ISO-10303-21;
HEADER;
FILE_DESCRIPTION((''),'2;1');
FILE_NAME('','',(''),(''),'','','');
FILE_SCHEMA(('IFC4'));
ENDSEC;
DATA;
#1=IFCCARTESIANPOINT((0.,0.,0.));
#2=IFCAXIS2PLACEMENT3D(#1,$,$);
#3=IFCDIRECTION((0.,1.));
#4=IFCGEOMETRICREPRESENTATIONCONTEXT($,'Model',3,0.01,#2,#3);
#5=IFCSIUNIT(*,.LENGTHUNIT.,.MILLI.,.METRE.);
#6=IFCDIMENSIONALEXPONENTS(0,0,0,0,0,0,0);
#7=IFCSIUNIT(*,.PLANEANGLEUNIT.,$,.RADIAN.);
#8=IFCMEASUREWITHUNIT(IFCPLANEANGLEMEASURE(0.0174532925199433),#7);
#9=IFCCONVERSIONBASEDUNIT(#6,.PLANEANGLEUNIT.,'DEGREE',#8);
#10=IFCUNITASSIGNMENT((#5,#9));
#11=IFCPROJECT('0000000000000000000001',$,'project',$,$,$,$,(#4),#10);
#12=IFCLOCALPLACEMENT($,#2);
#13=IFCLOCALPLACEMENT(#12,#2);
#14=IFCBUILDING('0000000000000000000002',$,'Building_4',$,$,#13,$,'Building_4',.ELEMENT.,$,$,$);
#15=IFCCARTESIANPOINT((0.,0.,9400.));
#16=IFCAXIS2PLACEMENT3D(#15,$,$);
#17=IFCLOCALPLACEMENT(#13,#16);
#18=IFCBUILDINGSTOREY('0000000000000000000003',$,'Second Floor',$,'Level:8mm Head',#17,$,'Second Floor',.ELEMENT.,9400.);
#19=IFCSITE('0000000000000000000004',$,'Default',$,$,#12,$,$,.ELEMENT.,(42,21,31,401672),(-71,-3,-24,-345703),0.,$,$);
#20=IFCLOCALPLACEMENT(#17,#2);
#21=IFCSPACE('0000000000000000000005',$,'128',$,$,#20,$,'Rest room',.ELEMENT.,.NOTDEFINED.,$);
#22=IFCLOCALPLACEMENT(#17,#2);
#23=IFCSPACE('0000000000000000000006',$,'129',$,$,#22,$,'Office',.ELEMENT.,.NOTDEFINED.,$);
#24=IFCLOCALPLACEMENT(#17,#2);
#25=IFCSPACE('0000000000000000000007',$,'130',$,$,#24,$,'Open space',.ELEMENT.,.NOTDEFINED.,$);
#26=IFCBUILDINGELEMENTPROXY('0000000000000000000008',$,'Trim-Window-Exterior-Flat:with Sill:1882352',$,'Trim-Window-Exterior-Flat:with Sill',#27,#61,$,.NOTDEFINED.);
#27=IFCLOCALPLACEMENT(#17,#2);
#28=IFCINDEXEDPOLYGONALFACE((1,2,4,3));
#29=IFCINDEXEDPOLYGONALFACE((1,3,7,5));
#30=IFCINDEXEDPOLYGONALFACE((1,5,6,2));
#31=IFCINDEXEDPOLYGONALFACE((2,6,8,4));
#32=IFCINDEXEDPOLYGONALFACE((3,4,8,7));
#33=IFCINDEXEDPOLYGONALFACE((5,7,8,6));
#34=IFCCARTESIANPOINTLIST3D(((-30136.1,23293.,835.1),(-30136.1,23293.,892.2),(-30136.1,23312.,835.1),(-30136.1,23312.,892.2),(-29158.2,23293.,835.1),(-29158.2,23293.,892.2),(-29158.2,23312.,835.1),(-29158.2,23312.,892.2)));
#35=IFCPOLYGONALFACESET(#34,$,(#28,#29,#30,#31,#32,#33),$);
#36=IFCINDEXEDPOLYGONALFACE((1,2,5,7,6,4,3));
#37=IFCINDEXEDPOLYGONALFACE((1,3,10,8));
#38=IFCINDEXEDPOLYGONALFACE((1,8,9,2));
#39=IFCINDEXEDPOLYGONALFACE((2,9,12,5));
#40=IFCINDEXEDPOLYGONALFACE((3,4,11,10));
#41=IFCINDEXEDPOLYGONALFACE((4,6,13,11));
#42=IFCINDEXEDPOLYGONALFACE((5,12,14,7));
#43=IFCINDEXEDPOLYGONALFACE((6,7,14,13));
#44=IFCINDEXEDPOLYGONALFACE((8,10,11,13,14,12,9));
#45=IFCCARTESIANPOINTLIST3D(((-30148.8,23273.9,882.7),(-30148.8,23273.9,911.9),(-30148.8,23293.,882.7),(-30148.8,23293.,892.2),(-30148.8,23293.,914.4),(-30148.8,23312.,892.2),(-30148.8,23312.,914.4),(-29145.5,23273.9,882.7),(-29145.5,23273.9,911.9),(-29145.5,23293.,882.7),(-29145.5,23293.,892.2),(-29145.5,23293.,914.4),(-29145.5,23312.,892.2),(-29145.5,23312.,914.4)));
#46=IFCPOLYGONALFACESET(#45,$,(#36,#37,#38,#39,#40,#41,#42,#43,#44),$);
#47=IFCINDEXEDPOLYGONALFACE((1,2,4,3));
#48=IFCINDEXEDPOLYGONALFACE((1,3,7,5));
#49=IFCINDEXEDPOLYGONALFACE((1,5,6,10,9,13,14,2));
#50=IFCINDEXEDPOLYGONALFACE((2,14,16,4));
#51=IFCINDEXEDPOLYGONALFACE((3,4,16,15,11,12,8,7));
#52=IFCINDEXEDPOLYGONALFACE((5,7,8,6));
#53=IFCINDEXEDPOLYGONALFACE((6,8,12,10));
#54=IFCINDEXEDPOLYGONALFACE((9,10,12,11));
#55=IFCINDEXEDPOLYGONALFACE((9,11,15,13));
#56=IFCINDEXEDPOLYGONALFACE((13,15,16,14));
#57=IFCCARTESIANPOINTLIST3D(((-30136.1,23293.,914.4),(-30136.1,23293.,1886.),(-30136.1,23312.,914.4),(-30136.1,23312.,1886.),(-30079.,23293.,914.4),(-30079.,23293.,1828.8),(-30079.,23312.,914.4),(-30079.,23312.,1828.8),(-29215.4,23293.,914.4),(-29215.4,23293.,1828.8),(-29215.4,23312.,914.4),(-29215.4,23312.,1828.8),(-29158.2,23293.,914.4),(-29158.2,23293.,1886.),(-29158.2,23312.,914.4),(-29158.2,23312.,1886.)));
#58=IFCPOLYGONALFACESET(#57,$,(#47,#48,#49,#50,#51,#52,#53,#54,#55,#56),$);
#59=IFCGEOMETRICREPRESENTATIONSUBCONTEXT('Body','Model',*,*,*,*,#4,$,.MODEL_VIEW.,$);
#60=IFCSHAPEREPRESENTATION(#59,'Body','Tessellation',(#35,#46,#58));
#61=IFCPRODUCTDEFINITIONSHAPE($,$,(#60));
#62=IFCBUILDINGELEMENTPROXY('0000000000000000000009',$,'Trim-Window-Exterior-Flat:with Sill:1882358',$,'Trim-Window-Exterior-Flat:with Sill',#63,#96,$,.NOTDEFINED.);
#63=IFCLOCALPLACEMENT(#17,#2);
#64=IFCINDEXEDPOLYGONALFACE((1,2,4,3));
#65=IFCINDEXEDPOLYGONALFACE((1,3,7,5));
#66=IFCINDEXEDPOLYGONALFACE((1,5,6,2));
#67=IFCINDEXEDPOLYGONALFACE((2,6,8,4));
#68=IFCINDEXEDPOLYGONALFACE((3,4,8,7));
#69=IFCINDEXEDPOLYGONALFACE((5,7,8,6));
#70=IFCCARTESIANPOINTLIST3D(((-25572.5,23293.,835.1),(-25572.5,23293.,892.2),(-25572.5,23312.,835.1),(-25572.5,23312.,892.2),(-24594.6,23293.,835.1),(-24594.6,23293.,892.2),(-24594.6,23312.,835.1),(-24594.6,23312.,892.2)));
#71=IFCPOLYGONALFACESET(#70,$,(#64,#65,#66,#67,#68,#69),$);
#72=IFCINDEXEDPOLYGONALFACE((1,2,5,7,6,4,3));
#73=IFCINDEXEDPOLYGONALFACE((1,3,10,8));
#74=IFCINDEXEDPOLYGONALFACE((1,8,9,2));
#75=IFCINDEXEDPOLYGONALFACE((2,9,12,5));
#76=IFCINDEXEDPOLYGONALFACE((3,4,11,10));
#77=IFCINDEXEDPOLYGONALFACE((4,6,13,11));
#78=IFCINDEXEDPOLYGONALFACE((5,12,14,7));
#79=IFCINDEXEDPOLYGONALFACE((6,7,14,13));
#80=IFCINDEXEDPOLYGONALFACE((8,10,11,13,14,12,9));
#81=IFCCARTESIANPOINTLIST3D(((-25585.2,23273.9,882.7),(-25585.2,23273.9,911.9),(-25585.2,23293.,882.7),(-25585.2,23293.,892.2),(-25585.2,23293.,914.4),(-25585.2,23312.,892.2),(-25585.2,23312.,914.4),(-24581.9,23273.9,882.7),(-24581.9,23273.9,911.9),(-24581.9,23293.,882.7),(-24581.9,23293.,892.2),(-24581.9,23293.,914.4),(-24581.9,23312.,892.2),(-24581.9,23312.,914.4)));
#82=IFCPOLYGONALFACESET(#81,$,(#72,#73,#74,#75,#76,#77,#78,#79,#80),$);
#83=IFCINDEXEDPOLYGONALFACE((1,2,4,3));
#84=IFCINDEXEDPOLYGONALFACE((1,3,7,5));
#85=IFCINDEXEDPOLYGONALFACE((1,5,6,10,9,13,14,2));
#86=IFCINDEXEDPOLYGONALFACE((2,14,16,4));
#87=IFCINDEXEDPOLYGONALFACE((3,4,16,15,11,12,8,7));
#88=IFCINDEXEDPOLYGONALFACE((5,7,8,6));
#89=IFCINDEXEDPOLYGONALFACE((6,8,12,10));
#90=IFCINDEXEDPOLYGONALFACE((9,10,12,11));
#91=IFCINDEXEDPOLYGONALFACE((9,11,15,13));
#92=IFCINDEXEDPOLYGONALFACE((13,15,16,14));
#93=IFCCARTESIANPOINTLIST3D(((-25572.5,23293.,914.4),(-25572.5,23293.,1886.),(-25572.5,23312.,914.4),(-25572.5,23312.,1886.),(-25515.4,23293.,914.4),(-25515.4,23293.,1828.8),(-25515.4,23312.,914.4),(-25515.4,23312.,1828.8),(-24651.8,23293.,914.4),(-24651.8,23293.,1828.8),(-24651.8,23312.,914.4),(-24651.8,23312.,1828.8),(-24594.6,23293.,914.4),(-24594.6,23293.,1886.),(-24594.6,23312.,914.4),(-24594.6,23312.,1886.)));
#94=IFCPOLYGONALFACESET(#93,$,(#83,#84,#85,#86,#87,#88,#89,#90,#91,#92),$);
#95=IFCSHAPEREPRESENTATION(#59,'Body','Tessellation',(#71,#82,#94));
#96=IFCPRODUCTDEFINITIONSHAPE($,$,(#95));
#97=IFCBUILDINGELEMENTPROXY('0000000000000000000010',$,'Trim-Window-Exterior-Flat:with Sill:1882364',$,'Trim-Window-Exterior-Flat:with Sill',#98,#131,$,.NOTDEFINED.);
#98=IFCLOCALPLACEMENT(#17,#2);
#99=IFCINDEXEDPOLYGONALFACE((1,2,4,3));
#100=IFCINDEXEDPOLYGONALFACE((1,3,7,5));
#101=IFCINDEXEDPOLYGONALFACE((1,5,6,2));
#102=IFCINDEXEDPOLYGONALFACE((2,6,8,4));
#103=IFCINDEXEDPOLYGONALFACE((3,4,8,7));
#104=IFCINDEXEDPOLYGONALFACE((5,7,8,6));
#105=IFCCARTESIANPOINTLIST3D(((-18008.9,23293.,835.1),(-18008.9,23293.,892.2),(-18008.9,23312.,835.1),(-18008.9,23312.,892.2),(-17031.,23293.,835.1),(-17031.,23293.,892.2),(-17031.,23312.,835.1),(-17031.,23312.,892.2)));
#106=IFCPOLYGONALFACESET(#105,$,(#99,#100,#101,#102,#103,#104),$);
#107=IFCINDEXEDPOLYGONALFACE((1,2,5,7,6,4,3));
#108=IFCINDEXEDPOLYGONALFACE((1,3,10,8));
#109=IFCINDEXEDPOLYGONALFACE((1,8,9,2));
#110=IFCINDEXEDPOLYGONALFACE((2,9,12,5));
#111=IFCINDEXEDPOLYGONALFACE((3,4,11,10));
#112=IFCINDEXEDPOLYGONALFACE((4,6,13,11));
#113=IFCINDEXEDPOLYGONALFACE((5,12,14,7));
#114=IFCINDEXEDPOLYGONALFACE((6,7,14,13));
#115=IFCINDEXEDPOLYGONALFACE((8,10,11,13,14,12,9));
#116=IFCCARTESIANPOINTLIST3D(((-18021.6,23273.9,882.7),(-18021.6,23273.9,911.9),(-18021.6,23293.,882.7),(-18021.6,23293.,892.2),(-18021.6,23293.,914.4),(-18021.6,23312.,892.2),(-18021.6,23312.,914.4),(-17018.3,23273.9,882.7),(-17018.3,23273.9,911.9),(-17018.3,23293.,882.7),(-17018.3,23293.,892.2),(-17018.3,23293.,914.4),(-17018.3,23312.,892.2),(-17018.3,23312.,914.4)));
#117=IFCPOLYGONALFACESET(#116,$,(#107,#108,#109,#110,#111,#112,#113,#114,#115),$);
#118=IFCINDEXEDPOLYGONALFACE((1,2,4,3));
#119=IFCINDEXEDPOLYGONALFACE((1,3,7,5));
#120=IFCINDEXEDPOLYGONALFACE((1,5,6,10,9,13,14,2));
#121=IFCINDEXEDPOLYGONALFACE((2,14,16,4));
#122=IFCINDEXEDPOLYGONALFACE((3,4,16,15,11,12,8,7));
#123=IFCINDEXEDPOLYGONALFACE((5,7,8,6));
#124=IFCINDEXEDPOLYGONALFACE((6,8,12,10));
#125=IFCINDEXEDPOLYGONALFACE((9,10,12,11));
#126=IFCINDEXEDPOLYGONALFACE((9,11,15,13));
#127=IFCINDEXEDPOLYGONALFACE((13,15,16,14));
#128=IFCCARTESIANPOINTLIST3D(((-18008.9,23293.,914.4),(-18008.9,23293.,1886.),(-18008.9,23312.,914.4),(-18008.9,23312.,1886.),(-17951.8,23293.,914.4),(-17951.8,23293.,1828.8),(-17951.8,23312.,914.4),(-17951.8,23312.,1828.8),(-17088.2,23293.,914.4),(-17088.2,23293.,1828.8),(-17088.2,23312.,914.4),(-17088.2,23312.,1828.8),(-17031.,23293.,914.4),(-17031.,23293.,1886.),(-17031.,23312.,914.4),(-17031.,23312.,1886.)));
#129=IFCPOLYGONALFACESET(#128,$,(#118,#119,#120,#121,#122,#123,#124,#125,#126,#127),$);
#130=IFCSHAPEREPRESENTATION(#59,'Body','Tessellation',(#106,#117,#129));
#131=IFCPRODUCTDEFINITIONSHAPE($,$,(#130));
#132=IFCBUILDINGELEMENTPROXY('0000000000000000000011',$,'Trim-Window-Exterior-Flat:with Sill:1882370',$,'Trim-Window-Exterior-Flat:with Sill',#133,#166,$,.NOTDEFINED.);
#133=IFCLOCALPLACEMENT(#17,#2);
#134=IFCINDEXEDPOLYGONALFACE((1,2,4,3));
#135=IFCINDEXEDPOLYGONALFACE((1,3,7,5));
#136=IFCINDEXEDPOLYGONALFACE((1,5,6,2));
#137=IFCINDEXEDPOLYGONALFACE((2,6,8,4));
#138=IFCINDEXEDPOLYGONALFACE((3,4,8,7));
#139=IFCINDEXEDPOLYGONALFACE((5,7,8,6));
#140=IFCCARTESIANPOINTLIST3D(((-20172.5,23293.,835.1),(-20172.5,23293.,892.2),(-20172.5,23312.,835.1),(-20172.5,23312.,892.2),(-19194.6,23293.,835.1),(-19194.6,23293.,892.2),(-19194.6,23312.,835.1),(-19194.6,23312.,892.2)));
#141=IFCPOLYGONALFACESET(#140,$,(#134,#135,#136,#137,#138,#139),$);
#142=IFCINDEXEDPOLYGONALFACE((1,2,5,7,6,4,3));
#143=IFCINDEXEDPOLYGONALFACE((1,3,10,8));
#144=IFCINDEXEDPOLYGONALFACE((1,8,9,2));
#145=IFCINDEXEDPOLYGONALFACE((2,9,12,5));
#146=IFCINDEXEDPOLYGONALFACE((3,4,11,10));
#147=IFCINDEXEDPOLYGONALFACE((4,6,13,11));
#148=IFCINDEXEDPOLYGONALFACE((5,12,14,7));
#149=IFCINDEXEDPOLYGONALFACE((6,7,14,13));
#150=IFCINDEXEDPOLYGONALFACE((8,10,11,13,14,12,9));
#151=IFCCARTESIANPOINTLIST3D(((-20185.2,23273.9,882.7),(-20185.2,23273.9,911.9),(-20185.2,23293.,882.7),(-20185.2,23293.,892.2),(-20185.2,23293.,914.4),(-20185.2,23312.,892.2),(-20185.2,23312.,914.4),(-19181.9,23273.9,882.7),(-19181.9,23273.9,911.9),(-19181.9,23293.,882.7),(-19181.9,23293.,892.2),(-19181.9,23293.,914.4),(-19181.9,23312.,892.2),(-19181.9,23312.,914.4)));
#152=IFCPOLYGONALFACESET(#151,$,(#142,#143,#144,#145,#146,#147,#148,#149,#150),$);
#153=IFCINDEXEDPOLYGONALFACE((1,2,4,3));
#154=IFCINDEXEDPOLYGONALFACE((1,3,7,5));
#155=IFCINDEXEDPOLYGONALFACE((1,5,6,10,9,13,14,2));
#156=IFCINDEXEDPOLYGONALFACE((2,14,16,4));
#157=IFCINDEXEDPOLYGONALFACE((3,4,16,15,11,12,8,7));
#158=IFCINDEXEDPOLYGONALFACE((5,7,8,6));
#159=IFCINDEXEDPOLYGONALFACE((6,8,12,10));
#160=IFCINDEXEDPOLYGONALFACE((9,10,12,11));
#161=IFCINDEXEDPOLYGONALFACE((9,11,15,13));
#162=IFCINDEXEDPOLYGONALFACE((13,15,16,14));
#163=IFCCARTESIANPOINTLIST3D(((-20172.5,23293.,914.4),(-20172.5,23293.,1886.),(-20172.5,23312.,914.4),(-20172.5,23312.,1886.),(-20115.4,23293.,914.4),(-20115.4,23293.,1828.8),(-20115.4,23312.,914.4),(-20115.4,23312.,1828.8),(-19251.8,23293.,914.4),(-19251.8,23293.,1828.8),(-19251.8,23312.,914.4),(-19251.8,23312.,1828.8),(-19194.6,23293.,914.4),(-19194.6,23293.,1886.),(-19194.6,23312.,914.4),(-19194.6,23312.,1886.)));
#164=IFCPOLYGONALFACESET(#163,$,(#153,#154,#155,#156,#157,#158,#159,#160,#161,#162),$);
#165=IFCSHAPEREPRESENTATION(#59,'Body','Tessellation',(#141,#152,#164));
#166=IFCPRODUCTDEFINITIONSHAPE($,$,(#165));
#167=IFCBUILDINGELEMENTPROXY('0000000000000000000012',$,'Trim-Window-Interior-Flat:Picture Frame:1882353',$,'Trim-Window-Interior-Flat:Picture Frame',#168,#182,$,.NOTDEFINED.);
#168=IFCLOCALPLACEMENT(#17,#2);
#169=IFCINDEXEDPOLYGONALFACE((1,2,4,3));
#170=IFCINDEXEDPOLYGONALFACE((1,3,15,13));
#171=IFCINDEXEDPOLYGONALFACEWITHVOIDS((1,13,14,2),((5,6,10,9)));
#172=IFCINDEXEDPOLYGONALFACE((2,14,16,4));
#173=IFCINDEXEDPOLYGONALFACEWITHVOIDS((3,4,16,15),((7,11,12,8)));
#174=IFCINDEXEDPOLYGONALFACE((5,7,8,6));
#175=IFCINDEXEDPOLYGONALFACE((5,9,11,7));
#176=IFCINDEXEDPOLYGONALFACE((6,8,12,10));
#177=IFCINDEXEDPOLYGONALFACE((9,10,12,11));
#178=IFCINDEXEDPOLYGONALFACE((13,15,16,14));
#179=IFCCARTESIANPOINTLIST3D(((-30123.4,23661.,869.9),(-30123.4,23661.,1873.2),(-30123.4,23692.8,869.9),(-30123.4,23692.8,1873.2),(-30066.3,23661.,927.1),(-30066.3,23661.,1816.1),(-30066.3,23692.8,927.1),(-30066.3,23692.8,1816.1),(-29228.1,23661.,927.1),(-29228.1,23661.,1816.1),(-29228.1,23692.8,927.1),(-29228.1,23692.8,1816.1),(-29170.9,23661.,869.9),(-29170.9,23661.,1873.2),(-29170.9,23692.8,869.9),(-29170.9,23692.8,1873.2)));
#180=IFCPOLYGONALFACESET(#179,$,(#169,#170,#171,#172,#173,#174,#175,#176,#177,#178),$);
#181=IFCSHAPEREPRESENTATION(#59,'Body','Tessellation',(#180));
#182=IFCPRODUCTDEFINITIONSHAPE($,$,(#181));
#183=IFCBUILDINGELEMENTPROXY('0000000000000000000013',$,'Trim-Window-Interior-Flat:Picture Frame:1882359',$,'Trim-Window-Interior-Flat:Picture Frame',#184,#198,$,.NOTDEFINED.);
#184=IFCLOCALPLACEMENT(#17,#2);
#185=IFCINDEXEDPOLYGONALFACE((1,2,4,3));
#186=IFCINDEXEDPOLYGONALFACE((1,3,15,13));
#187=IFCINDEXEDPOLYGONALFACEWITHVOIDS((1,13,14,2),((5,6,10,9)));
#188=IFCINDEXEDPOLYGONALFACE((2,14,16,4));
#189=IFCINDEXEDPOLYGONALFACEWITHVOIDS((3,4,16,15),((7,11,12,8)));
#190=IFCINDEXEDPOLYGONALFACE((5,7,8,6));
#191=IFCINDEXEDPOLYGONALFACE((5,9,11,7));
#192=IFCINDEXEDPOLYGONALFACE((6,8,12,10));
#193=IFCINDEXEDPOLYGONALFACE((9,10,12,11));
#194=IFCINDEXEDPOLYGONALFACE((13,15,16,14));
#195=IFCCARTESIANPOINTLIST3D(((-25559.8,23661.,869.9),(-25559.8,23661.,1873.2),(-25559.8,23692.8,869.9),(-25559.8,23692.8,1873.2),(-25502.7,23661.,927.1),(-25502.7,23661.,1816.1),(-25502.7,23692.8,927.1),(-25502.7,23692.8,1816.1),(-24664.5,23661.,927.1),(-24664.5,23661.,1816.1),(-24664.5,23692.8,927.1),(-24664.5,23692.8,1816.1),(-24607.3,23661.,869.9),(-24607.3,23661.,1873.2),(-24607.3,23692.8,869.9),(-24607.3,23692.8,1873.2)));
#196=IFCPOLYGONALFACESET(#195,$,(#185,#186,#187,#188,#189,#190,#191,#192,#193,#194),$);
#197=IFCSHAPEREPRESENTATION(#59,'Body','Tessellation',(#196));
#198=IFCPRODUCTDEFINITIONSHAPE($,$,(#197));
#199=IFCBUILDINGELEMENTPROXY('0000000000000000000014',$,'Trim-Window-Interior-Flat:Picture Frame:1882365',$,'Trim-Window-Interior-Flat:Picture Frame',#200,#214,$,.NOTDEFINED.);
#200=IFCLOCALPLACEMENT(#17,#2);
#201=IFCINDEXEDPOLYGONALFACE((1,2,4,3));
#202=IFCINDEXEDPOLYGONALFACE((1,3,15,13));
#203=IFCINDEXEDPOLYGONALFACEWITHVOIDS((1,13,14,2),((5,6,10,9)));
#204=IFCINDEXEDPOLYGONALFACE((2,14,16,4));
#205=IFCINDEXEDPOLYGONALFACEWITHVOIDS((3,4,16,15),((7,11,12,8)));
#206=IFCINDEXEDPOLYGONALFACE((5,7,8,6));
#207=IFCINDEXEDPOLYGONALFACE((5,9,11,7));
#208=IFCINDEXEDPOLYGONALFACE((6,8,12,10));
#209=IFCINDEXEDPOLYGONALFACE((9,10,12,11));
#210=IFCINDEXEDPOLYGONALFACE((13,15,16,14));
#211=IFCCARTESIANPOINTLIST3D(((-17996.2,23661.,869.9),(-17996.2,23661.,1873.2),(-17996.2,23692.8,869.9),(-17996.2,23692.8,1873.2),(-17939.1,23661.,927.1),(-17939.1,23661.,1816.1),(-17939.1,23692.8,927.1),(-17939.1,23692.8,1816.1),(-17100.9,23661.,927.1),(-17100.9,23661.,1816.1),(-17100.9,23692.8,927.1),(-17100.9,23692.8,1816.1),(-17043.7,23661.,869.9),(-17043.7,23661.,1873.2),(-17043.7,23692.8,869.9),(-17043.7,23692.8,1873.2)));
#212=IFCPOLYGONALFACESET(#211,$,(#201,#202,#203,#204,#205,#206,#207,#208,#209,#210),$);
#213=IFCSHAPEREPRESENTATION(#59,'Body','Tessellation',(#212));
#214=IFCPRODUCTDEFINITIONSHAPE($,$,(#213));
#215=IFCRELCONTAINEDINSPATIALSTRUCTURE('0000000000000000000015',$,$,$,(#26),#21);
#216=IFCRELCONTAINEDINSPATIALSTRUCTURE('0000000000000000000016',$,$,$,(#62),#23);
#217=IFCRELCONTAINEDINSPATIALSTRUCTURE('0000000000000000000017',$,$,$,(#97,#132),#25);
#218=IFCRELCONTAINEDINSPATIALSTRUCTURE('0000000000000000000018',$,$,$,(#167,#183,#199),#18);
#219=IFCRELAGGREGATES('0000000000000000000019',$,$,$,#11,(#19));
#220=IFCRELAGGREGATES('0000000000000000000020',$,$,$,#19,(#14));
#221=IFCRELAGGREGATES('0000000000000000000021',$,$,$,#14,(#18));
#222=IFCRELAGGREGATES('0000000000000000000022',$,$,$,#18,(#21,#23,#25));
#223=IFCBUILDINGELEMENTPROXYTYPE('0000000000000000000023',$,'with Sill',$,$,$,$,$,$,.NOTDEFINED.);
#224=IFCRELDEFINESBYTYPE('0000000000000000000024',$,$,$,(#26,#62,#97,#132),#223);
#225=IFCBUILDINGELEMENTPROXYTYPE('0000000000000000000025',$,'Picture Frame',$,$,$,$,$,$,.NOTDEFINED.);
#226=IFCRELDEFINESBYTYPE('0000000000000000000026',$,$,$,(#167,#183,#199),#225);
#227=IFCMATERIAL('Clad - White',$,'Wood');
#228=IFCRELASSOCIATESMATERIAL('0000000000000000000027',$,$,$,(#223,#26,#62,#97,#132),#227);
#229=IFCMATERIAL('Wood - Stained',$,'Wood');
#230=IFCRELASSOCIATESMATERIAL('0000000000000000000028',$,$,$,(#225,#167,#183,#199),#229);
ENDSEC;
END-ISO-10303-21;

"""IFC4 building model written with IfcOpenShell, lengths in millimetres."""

from ifc_helpers import new_model, entity, si_unit, converted_unit, direction, frame, origin, place, context, subcontext, project, spatial, indexed_curve, outline, extrude, source, transform, mapped, material, type_object, type_shapes, element, save


model = new_model("IFC4")

# Units and contexts
model_context = context("Model", 3, precision=0.01, world=origin(), true_north=direction((0.0, 1.0)))
body_context = subcontext(model_context, "Body", "Model", "MODEL_VIEW")
ifc_project = project(units=[si_unit("LENGTHUNIT", "METRE", prefix="MILLI"), converted_unit("PLANEANGLEUNIT", "DEGREE", entity("IfcPlaneAngleMeasure", 0.0174532925199433), si_unit("PLANEANGLEUNIT", "RADIAN"), dimensions=[0, 0, 0, 0, 0, 0, 0])], contexts=[model_context])

# Site, building, storey
site_placement = place(None, origin())
site = spatial("IfcSite", under=ifc_project, at=site_placement, Name="Default", CompositionType="ELEMENT", RefLatitude=(42, 21, 31, 401672), RefLongitude=(-71, -3, -24, -345703), RefElevation=0.0)
building_placement = place(site_placement, origin())
building = spatial("IfcBuilding", under=site, at=building_placement, Name="Building_4", LongName="Building_4", CompositionType="ELEMENT")
storey_placement = place(building_placement, frame((0.0, 0.0, 9400.0)))
storey = spatial("IfcBuildingStorey", under=building, at=storey_placement, Name="Second Floor", ObjectType="Level:8mm Head", LongName="Second Floor", CompositionType="ELEMENT", Elevation=9400.0)

# Shared definitions
ifc_material_1 = material(Name="Clad - White", Category="Wood")
ifc_material_2 = material(Name="Wood - Stained", Category="Wood")

# Shared definitions
space_1_placement = place(storey_placement, origin())
space_1 = spatial("IfcSpace", under=storey, at=space_1_placement, Name="128", LongName="Rest room", CompositionType="ELEMENT", PredefinedType="NOTDEFINED")

# Building element proxy
building_element_proxy_type_1 = type_object("IfcBuildingElementProxyType", Name="with Sill", PredefinedType="NOTDEFINED", material=ifc_material_1)
shared_shape_1 = source(origin(), body_context, "Body", "SweptSolid", [
    extrude(outline(indexed_curve([(-488.9, -28.6), (488.9, -28.6), (488.9, 28.6), (-488.9, 28.6), (-488.9, -28.6)], self_intersect=False)), frame((0.0, -965.2, 0.0), z_axis=(0.0, 0.0, 1.0), x_axis=(-1.0, 0.0, 0.0)), (0.0, 0.0, 1.0), 19.1),
    extrude(outline(indexed_curve([(-19.0, -16.0), (0.0, -16.0), (0.0, -6.4), (19.0, -6.4), (19.0, 15.8), (0.0, 15.8), (-19.0, 13.3), (-19.0, -16.0)], self_intersect=False)), frame((-501.6, -930.2, 19.0), z_axis=(1.0, 0.0, 0.0), x_axis=(0.0, 0.0, -1.0)), (0.0, 0.0, 1.0), 1003.3),
    extrude(outline(indexed_curve([(-500.1, -488.9), (471.5, -488.9), (471.5, -431.8), (-442.9, -431.8), (-442.9, 431.8), (471.5, 431.8), (471.5, 488.9), (-500.1, 488.9), (-500.1, -488.9)], self_intersect=False)), frame((0.0, -442.9, 0.0), z_axis=(0.0, 0.0, 1.0), x_axis=(0.0, -1.0, 0.0)), (0.0, 0.0, 1.0), 19.1),
])
type_shapes(building_element_proxy_type_1, [shared_shape_1])
proxy_1_placement = place(space_1_placement, frame((-29647.2, 23312.0, 1828.8), z_axis=(0.0, -1.0, 0.0), x_axis=(1.0, 0.0, 0.0)))
element("IfcBuildingElementProxy", 1, at=proxy_1_placement, inside=space_1, type_object=building_element_proxy_type_1, material=ifc_material_1, Name="Trim-Window-Exterior-Flat:with Sill:1882352", ObjectType="Trim-Window-Exterior-Flat:with Sill", PredefinedType="NOTDEFINED", context=body_context, shape_type="MappedRepresentation", body=[
    mapped(shared_shape_1, transform((0.0, 0.0, 0.0), scale=1.0)),
])

# Shared definitions
space_2_placement = place(storey_placement, origin())
space_2 = spatial("IfcSpace", under=storey, at=space_2_placement, Name="129", LongName="Office", CompositionType="ELEMENT", PredefinedType="NOTDEFINED")

# Building element proxy
proxy_2_placement = place(space_2_placement, frame((-25083.6, 23312.0, 1828.8), z_axis=(0.0, -1.0, 0.0), x_axis=(1.0, 0.0, 0.0)))
element("IfcBuildingElementProxy", 2, at=proxy_2_placement, inside=space_2, type_object=building_element_proxy_type_1, material=ifc_material_1, Name="Trim-Window-Exterior-Flat:with Sill:1882358", ObjectType="Trim-Window-Exterior-Flat:with Sill", PredefinedType="NOTDEFINED", context=body_context, shape_type="MappedRepresentation", body=[
    mapped(shared_shape_1, transform((0.0, 0.0, 0.0), scale=1.0)),
])

# Shared definitions
space_3_placement = place(storey_placement, origin())
space_3 = spatial("IfcSpace", under=storey, at=space_3_placement, Name="130", LongName="Open space", CompositionType="ELEMENT", PredefinedType="NOTDEFINED")

# Building element proxies
for number, where, z_axis, x_axis, name in (
    (3, (-17520.0, 23312.0, 1828.8), (0.0, -1.0, 0.0), (1.0, 0.0, 0.0), "Trim-Window-Exterior-Flat:with Sill:1882364"),
    (4, (-19683.6, 23312.0, 1828.8), (0.0, -1.0, 0.0), (1.0, 0.0, 0.0), "Trim-Window-Exterior-Flat:with Sill:1882370"),
):
    element("IfcBuildingElementProxy", number, at=place(space_3_placement, frame(where, z_axis=z_axis, x_axis=x_axis)), inside=space_3, type_object=building_element_proxy_type_1, material=ifc_material_1, Name=name, ObjectType="Trim-Window-Exterior-Flat:with Sill", PredefinedType="NOTDEFINED", context=body_context, shape_type="MappedRepresentation", body=[
        mapped(shared_shape_1, transform((0.0, 0.0, 0.0), scale=1.0)),
    ])
building_element_proxy_type_2 = type_object("IfcBuildingElementProxyType", Name="Picture Frame", PredefinedType="NOTDEFINED", material=ifc_material_2)
shared_shape_2 = source(origin(), body_context, "Body", "SweptSolid", [
    extrude(outline(indexed_curve([(-476.2, -501.6), (476.2, -501.6), (476.2, 501.6), (-476.2, 501.6), (-476.2, -501.6)], self_intersect=False), holes=[indexed_curve([(-419.1, -444.5), (-419.1, 444.5), (419.1, 444.5), (419.1, -444.5), (-419.1, -444.5)], self_intersect=False)]), frame((0.0, -457.2, 0.0), z_axis=(0.0, 0.0, 1.0), x_axis=(-1.0, 0.0, 0.0)), (0.0, 0.0, 1.0), 31.8),
])
type_shapes(building_element_proxy_type_2, [shared_shape_2])
for number, where, z_axis, x_axis, name in (
    (5, (-29647.2, 23661.0, 1828.8), (0.0, 1.0, 0.0), (-1.0, 0.0, 0.0), "Trim-Window-Interior-Flat:Picture Frame:1882353"),
    (6, (-25083.6, 23661.0, 1828.8), (0.0, 1.0, 0.0), (-1.0, 0.0, 0.0), "Trim-Window-Interior-Flat:Picture Frame:1882359"),
    (7, (-17520.0, 23661.0, 1828.8), (0.0, 1.0, 0.0), (-1.0, 0.0, 0.0), "Trim-Window-Interior-Flat:Picture Frame:1882365"),
):
    element("IfcBuildingElementProxy", number, at=place(storey_placement, frame(where, z_axis=z_axis, x_axis=x_axis)), inside=storey, type_object=building_element_proxy_type_2, material=ifc_material_2, Name=name, ObjectType="Trim-Window-Interior-Flat:Picture Frame", PredefinedType="NOTDEFINED", context=body_context, shape_type="MappedRepresentation", body=[
        mapped(shared_shape_2, transform((0.0, 0.0, 0.0), scale=1.0)),
    ])

save(model, "model.ifc")
